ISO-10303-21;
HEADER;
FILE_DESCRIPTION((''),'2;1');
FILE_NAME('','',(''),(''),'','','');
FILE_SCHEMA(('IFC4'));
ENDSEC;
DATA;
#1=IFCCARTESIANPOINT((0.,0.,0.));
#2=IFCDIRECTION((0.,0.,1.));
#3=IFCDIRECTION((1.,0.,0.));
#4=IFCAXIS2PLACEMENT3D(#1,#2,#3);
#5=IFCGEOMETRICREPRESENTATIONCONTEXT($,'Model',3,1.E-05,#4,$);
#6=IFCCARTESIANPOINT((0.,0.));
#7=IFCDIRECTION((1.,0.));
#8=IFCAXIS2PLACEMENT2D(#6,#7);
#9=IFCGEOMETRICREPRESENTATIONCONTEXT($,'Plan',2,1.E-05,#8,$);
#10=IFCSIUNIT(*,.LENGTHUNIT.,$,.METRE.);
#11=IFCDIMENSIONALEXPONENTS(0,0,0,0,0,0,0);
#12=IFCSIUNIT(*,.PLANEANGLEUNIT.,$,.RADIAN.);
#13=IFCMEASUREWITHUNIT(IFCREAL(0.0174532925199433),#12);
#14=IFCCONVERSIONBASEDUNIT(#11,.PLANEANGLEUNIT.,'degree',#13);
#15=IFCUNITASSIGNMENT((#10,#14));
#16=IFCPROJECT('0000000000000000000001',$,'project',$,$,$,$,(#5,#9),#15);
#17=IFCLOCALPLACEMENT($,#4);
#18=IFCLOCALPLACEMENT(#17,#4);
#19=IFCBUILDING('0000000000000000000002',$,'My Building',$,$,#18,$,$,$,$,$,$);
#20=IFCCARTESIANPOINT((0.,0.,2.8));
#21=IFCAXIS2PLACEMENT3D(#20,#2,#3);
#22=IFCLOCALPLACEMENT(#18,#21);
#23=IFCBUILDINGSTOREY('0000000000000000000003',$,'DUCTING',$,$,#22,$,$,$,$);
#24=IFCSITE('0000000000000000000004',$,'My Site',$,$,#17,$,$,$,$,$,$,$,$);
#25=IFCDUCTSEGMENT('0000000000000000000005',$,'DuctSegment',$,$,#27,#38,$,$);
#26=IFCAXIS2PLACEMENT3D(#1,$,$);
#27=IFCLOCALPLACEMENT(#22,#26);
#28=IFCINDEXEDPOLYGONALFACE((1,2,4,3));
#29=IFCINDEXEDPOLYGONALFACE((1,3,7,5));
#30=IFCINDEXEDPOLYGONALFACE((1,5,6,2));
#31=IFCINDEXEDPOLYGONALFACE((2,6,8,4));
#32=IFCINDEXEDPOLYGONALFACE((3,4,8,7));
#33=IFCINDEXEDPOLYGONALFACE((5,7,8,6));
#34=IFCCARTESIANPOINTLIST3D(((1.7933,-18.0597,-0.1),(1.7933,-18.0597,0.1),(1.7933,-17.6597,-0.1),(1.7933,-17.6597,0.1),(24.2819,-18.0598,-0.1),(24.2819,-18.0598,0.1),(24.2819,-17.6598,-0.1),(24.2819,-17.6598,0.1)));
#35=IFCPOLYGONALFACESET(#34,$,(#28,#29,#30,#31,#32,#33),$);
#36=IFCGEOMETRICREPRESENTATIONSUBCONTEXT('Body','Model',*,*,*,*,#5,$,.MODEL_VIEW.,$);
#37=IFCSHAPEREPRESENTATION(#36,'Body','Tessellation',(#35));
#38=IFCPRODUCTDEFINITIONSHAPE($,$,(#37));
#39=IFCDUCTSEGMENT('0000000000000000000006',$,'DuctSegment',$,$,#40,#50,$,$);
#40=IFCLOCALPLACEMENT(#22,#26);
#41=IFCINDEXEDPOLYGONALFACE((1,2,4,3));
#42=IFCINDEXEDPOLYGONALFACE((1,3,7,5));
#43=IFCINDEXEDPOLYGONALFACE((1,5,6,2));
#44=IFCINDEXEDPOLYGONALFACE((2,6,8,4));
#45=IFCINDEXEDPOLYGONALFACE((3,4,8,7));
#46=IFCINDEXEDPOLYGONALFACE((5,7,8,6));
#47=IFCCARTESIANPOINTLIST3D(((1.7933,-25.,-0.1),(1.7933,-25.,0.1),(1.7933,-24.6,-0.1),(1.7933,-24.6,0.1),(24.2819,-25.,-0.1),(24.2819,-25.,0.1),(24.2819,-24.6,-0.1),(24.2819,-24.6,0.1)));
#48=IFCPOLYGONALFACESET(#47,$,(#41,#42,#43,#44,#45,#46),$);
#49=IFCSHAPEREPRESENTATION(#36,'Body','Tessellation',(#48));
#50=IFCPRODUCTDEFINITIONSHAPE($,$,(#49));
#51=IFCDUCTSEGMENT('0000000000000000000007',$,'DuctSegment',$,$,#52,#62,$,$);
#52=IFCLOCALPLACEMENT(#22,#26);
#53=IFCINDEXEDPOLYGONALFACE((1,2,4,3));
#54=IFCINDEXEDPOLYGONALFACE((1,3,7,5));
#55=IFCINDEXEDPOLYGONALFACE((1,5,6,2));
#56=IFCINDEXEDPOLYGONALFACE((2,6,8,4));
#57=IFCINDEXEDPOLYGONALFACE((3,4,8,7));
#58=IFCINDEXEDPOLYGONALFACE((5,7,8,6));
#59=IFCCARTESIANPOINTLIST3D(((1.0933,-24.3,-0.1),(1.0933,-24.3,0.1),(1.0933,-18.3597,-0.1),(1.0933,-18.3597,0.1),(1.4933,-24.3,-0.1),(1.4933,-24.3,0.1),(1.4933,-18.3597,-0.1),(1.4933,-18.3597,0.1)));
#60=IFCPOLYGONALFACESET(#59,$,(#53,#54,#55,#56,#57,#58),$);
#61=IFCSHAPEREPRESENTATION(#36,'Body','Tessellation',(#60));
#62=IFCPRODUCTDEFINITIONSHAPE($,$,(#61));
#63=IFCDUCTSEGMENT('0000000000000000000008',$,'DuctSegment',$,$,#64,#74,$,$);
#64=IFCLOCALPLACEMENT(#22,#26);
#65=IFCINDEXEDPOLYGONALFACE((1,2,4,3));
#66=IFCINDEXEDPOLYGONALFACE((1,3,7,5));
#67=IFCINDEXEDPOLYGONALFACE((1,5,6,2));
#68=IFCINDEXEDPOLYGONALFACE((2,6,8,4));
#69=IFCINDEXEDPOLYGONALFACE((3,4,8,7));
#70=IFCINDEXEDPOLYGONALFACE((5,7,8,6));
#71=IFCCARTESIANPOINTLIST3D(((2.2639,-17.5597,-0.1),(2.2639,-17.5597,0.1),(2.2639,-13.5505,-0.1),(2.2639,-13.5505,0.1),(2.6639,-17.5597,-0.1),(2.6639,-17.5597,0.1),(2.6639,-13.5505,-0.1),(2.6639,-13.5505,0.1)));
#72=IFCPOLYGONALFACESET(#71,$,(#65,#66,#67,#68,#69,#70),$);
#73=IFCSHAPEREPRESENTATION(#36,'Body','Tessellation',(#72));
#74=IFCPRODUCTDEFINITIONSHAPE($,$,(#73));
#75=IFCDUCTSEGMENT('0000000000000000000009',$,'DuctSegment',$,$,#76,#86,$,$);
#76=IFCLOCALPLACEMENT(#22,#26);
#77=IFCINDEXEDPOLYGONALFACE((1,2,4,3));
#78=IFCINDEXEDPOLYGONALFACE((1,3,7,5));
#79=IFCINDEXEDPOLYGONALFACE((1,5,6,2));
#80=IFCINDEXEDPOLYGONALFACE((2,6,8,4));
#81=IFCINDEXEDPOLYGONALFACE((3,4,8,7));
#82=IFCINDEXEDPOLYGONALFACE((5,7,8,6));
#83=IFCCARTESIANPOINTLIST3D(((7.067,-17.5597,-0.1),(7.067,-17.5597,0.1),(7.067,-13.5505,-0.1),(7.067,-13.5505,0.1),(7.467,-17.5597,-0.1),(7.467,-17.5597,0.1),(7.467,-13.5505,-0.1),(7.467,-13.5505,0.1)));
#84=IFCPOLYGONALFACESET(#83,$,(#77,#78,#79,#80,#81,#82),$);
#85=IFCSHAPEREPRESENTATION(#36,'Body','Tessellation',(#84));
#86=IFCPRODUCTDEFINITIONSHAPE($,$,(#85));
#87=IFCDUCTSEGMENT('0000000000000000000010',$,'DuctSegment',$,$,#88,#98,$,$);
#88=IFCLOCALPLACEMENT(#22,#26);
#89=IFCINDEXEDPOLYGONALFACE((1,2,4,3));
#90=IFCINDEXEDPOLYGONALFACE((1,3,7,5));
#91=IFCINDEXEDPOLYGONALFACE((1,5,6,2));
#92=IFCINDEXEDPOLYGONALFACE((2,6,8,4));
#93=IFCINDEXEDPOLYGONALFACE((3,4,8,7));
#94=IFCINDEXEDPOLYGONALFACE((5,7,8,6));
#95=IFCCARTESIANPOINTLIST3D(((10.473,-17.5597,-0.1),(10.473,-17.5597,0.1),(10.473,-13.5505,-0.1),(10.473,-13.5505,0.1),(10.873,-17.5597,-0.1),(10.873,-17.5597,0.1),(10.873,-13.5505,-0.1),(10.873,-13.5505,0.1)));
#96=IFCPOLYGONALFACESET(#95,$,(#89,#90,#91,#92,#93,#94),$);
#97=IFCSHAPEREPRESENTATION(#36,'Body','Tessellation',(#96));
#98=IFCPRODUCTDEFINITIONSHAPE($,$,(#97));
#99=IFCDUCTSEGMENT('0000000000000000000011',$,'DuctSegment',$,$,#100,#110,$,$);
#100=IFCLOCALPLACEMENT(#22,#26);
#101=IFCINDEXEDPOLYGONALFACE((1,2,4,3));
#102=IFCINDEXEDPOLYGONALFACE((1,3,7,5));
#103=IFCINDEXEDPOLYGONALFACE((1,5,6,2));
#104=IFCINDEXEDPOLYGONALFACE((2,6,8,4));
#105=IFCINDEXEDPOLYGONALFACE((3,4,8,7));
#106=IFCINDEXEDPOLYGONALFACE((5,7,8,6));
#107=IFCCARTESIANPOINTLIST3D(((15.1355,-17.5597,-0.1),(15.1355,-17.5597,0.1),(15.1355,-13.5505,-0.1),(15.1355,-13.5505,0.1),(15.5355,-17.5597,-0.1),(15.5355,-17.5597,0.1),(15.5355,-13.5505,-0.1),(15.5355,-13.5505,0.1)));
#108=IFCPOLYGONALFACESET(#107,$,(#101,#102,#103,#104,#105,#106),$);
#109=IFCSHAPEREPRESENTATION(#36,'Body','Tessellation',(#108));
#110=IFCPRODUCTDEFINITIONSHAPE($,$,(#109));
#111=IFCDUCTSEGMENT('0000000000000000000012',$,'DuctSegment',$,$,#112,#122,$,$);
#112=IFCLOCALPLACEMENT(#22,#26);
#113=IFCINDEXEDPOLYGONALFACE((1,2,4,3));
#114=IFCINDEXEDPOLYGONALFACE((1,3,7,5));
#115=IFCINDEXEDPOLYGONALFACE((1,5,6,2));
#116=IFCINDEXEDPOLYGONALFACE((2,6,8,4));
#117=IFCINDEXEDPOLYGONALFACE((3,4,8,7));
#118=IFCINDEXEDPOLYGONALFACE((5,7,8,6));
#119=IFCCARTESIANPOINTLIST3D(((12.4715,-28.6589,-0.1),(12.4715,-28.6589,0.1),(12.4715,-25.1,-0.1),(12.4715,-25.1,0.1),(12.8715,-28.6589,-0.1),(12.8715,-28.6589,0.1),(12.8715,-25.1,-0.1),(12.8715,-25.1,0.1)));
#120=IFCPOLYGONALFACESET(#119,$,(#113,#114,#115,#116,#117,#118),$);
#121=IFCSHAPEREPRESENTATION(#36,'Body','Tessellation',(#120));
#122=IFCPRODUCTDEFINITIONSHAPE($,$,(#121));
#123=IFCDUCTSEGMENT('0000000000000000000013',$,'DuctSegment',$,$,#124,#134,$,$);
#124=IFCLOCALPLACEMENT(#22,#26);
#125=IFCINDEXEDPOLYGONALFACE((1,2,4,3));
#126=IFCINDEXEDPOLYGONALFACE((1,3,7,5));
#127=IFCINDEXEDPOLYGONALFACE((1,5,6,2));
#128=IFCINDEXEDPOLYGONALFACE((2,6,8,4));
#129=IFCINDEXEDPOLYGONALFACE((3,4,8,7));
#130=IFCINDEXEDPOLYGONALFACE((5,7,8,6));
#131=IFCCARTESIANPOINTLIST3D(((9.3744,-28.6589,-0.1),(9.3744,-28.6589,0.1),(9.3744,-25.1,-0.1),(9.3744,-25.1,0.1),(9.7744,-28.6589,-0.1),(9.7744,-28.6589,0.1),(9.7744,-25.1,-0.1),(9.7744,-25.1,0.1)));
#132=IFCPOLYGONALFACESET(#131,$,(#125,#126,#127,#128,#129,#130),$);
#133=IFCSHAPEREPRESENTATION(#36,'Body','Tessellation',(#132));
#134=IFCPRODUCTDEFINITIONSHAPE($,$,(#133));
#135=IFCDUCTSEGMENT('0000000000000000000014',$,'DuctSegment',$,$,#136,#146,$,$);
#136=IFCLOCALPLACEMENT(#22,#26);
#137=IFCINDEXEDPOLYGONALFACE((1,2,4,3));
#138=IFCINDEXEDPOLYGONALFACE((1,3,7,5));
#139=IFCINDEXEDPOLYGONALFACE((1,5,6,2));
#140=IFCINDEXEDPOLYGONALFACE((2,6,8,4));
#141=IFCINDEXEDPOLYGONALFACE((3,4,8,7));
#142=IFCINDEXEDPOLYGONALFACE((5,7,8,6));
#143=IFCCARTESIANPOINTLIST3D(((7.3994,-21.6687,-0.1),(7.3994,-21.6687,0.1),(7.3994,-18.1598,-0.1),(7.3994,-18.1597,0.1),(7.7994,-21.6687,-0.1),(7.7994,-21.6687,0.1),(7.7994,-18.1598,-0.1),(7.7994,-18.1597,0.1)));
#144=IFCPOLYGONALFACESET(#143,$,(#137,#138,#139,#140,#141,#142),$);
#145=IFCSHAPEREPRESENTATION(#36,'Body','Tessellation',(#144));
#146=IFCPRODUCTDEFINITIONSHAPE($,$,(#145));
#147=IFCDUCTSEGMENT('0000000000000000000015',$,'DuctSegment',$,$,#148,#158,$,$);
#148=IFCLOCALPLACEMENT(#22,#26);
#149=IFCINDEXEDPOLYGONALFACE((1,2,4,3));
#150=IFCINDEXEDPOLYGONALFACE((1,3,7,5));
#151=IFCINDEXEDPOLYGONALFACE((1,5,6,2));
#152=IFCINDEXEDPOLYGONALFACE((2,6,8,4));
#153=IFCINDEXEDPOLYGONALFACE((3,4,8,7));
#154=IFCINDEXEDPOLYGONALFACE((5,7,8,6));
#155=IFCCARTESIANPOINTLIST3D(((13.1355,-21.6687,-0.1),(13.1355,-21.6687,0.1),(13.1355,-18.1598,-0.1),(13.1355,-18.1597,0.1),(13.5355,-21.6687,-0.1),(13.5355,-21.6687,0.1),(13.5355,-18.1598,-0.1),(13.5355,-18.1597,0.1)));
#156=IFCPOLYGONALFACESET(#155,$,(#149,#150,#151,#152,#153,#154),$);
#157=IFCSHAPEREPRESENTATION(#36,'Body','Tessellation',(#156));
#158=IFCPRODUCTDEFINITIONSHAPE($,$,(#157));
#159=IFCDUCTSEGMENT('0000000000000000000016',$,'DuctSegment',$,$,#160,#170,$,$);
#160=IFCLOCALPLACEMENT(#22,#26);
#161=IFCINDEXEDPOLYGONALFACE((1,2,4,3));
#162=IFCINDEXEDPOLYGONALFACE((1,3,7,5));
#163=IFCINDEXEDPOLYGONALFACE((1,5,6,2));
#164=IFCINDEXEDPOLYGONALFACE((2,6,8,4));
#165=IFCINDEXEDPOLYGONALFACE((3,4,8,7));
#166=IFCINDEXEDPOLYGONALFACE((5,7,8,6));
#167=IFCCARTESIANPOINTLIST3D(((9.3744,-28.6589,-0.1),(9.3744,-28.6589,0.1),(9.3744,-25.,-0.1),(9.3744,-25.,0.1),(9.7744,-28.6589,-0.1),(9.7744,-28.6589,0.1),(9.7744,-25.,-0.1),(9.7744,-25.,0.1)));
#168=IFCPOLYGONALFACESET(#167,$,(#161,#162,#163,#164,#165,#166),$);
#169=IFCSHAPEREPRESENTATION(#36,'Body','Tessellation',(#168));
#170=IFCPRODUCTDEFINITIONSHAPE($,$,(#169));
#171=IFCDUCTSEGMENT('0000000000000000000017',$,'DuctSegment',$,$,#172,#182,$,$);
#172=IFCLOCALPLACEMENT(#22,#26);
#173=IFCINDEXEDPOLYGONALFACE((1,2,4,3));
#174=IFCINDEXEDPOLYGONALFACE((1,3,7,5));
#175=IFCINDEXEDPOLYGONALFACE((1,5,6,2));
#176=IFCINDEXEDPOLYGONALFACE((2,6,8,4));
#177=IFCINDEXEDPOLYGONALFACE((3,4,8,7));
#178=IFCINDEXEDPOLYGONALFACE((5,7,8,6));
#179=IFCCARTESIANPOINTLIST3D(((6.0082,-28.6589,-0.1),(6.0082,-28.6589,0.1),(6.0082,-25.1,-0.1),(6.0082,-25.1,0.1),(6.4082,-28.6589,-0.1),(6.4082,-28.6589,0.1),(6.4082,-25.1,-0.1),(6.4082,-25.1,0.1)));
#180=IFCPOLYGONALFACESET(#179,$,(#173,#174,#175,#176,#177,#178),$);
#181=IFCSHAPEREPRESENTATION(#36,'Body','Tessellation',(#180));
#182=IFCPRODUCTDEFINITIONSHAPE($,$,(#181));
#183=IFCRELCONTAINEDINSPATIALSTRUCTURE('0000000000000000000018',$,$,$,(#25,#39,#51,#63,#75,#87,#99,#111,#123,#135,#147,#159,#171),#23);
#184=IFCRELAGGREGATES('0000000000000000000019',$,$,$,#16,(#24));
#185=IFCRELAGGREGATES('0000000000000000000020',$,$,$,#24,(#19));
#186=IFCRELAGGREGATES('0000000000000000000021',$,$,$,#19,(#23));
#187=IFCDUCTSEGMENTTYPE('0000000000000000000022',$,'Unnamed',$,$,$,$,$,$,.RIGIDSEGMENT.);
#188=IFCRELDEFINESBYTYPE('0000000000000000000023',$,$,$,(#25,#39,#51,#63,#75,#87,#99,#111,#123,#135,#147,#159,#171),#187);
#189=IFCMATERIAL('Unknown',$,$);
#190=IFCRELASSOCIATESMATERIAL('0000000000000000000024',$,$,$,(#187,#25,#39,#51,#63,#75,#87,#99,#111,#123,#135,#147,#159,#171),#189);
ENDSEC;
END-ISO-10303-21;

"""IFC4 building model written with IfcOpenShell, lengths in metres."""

from ifc_helpers import new_model, entity, si_unit, converted_unit, frame, origin_with_axes, origin_2d_with_axis, place, context, subcontext, project, spatial, rectangle, extrude, material, material_profile, profile_set, profile_usage, type_object, element, save


model = new_model("IFC4")

# Units and contexts
model_context = context("Model", 3, precision=1e-05, world=origin_with_axes())
plan_context = context("Plan", 2, precision=1e-05, world=origin_2d_with_axis())
body_context = subcontext(model_context, "Body", "Model", "MODEL_VIEW")
ifc_project = project(units=[si_unit("LENGTHUNIT", "METRE"), converted_unit("PLANEANGLEUNIT", "degree", entity("IfcReal", 0.0174532925199433), si_unit("PLANEANGLEUNIT", "RADIAN"), dimensions=[0, 0, 0, 0, 0, 0, 0])], contexts=[model_context, plan_context])

# Site, building, storey
site_placement = place(None, origin_with_axes())
site = spatial("IfcSite", under=ifc_project, at=site_placement, Name="My Site")
building_placement = place(site_placement, origin_with_axes())
building = spatial("IfcBuilding", under=site, at=building_placement, Name="My Building")
storey_placement = place(building_placement, frame((0.0, 0.0, 2.8), z_axis=(0.0, 0.0, 1.0), x_axis=(1.0, 0.0, 0.0)))
storey = spatial("IfcBuildingStorey", under=building, at=storey_placement, Name="DUCTING")

# Duct segments
ifc_material = material(Name="Unknown")
ifc_material_profile_1 = material_profile(ifc_material, rectangle(XDim=0.4, YDim=0.2))
ifc_profile_set_1 = profile_set([ifc_material_profile_1])
ifc_profile_usage_1 = profile_usage(ifc_profile_set_1, cardinal=5)
duct_segment_type = type_object("IfcDuctSegmentType", Name="Unnamed", PredefinedType="RIGIDSEGMENT", material=ifc_profile_set_1)
duct_segment_1_placement = place(storey_placement, frame((1.7933, -17.8597, 0.0), z_axis=(1.0, 0.0, 0.0), x_axis=(0.0, 1.0, 0.0)))
element("IfcDuctSegment", 1, at=duct_segment_1_placement, inside=storey, type_object=duct_segment_type, material=ifc_profile_usage_1, Name="DuctSegment", context=body_context, shape_type="SweptSolid", body=[
    extrude(rectangle(XDim=0.4, YDim=0.2), origin_with_axes(), (0.0, 0.0, 1.0), 22.4885),
])
ifc_profile_usage_2 = profile_usage(ifc_profile_set_1, cardinal=5)
duct_segment_2_placement = place(storey_placement, frame((1.7933, -24.8, 0.0), z_axis=(1.0, 0.0, 0.0), x_axis=(0.0, 1.0, 0.0)))
element("IfcDuctSegment", 2, at=duct_segment_2_placement, inside=storey, type_object=duct_segment_type, material=ifc_profile_usage_2, Name="DuctSegment", context=body_context, shape_type="SweptSolid", body=[
    extrude(rectangle(XDim=0.4, YDim=0.2), origin_with_axes(), (0.0, 0.0, 1.0), 22.4885),
])
ifc_profile_usage_3 = profile_usage(ifc_profile_set_1, cardinal=5)
duct_segment_3_placement = place(storey_placement, frame((1.2933, -18.3597, 0.0), z_axis=(0.0, -1.0, 0.0), x_axis=(1.0, 0.0, 0.0)))
element("IfcDuctSegment", 3, at=duct_segment_3_placement, inside=storey, type_object=duct_segment_type, material=ifc_profile_usage_3, Name="DuctSegment", context=body_context, shape_type="SweptSolid", body=[
    extrude(rectangle(XDim=0.4, YDim=0.2), origin_with_axes(), (0.0, 0.0, 1.0), 5.9403),
])
ifc_profile_usage_4 = profile_usage(ifc_profile_set_1, cardinal=5)
duct_segment_4_placement = place(storey_placement, frame((2.4639, -13.5505, 0.0), z_axis=(0.0, -1.0, 0.0), x_axis=(1.0, 0.0, 0.0)))
element("IfcDuctSegment", 4, at=duct_segment_4_placement, inside=storey, type_object=duct_segment_type, material=ifc_profile_usage_4, Name="DuctSegment", context=body_context, shape_type="SweptSolid", body=[
    extrude(rectangle(XDim=0.4, YDim=0.2), origin_with_axes(), (0.0, 0.0, 1.0), 4.0092),
])
ifc_profile_usage_5 = profile_usage(ifc_profile_set_1, cardinal=5)
duct_segment_5_placement = place(storey_placement, frame((7.267, -13.5505, 0.0), z_axis=(0.0, -1.0, 0.0), x_axis=(1.0, 0.0, 0.0)))
element("IfcDuctSegment", 5, at=duct_segment_5_placement, inside=storey, type_object=duct_segment_type, material=ifc_profile_usage_5, Name="DuctSegment", context=body_context, shape_type="SweptSolid", body=[
    extrude(rectangle(XDim=0.4, YDim=0.2), origin_with_axes(), (0.0, 0.0, 1.0), 4.0092),
])
ifc_profile_usage_6 = profile_usage(ifc_profile_set_1, cardinal=5)
duct_segment_6_placement = place(storey_placement, frame((10.673, -13.5505, 0.0), z_axis=(0.0, -1.0, 0.0), x_axis=(1.0, 0.0, 0.0)))
element("IfcDuctSegment", 6, at=duct_segment_6_placement, inside=storey, type_object=duct_segment_type, material=ifc_profile_usage_6, Name="DuctSegment", context=body_context, shape_type="SweptSolid", body=[
    extrude(rectangle(XDim=0.4, YDim=0.2), origin_with_axes(), (0.0, 0.0, 1.0), 4.0092),
])
ifc_profile_usage_7 = profile_usage(ifc_profile_set_1, cardinal=5)
duct_segment_7_placement = place(storey_placement, frame((15.3355, -13.5505, 0.0), z_axis=(0.0, -1.0, 0.0), x_axis=(1.0, 0.0, 0.0)))
element("IfcDuctSegment", 7, at=duct_segment_7_placement, inside=storey, type_object=duct_segment_type, material=ifc_profile_usage_7, Name="DuctSegment", context=body_context, shape_type="SweptSolid", body=[
    extrude(rectangle(XDim=0.4, YDim=0.2), origin_with_axes(), (0.0, 0.0, 1.0), 4.0092),
])
ifc_profile_usage_8 = profile_usage(ifc_profile_set_1, cardinal=5)
duct_segment_8_placement = place(storey_placement, frame((12.6715, -25.1, 0.0), z_axis=(0.0, -1.0, 0.0), x_axis=(1.0, 0.0, 0.0)))
element("IfcDuctSegment", 8, at=duct_segment_8_placement, inside=storey, type_object=duct_segment_type, material=ifc_profile_usage_8, Name="DuctSegment", context=body_context, shape_type="SweptSolid", body=[
    extrude(rectangle(XDim=0.4, YDim=0.2), origin_with_axes(), (0.0, 0.0, 1.0), 3.5589),
])
ifc_profile_usage_9 = profile_usage(ifc_profile_set_1, cardinal=5)
duct_segment_9_placement = place(storey_placement, frame((9.5744, -25.1, 0.0), z_axis=(0.0, -1.0, 0.0), x_axis=(1.0, 0.0, 0.0)))
element("IfcDuctSegment", 9, at=duct_segment_9_placement, inside=storey, type_object=duct_segment_type, material=ifc_profile_usage_9, Name="DuctSegment", context=body_context, shape_type="SweptSolid", body=[
    extrude(rectangle(XDim=0.4, YDim=0.2), origin_with_axes(), (0.0, 0.0, 1.0), 3.5589),
])
ifc_profile_usage_10 = profile_usage(ifc_profile_set_1, cardinal=5)
duct_segment_10_placement = place(storey_placement, frame((7.5994, -18.1597, 0.0), z_axis=(0.0, -1.0, 0.0), x_axis=(1.0, 0.0, 0.0)))
element("IfcDuctSegment", 10, at=duct_segment_10_placement, inside=storey, type_object=duct_segment_type, material=ifc_profile_usage_10, Name="DuctSegment", context=body_context, shape_type="SweptSolid", body=[
    extrude(rectangle(XDim=0.4, YDim=0.2), origin_with_axes(), (0.0, 0.0, 1.0), 3.5089),
])
ifc_profile_usage_11 = profile_usage(ifc_profile_set_1, cardinal=5)
duct_segment_11_placement = place(storey_placement, frame((13.3355, -18.1597, 0.0), z_axis=(0.0, -1.0, 0.0), x_axis=(1.0, 0.0, 0.0)))
element("IfcDuctSegment", 11, at=duct_segment_11_placement, inside=storey, type_object=duct_segment_type, material=ifc_profile_usage_11, Name="DuctSegment", context=body_context, shape_type="SweptSolid", body=[
    extrude(rectangle(XDim=0.4, YDim=0.2), origin_with_axes(), (0.0, 0.0, 1.0), 3.5089),
])
ifc_profile_usage_12 = profile_usage(ifc_profile_set_1, cardinal=5)
duct_segment_12_placement = place(storey_placement, frame((9.5744, -25.0, 0.0), z_axis=(0.0, -1.0, 0.0), x_axis=(1.0, 0.0, 0.0)))
element("IfcDuctSegment", 12, at=duct_segment_12_placement, inside=storey, type_object=duct_segment_type, material=ifc_profile_usage_12, Name="DuctSegment", context=body_context, shape_type="SweptSolid", body=[
    extrude(rectangle(XDim=0.4, YDim=0.2), origin_with_axes(), (0.0, 0.0, 1.0), 3.6589),
])
ifc_profile_usage_13 = profile_usage(ifc_profile_set_1, cardinal=5)
duct_segment_13_placement = place(storey_placement, frame((6.2082, -25.1, 0.0), z_axis=(0.0, -1.0, 0.0), x_axis=(1.0, 0.0, 0.0)))
element("IfcDuctSegment", 13, at=duct_segment_13_placement, inside=storey, type_object=duct_segment_type, material=ifc_profile_usage_13, Name="DuctSegment", context=body_context, shape_type="SweptSolid", body=[
    extrude(rectangle(XDim=0.4, YDim=0.2), origin_with_axes(), (0.0, 0.0, 1.0), 3.5589),
])

save(model, "model.ifc")
